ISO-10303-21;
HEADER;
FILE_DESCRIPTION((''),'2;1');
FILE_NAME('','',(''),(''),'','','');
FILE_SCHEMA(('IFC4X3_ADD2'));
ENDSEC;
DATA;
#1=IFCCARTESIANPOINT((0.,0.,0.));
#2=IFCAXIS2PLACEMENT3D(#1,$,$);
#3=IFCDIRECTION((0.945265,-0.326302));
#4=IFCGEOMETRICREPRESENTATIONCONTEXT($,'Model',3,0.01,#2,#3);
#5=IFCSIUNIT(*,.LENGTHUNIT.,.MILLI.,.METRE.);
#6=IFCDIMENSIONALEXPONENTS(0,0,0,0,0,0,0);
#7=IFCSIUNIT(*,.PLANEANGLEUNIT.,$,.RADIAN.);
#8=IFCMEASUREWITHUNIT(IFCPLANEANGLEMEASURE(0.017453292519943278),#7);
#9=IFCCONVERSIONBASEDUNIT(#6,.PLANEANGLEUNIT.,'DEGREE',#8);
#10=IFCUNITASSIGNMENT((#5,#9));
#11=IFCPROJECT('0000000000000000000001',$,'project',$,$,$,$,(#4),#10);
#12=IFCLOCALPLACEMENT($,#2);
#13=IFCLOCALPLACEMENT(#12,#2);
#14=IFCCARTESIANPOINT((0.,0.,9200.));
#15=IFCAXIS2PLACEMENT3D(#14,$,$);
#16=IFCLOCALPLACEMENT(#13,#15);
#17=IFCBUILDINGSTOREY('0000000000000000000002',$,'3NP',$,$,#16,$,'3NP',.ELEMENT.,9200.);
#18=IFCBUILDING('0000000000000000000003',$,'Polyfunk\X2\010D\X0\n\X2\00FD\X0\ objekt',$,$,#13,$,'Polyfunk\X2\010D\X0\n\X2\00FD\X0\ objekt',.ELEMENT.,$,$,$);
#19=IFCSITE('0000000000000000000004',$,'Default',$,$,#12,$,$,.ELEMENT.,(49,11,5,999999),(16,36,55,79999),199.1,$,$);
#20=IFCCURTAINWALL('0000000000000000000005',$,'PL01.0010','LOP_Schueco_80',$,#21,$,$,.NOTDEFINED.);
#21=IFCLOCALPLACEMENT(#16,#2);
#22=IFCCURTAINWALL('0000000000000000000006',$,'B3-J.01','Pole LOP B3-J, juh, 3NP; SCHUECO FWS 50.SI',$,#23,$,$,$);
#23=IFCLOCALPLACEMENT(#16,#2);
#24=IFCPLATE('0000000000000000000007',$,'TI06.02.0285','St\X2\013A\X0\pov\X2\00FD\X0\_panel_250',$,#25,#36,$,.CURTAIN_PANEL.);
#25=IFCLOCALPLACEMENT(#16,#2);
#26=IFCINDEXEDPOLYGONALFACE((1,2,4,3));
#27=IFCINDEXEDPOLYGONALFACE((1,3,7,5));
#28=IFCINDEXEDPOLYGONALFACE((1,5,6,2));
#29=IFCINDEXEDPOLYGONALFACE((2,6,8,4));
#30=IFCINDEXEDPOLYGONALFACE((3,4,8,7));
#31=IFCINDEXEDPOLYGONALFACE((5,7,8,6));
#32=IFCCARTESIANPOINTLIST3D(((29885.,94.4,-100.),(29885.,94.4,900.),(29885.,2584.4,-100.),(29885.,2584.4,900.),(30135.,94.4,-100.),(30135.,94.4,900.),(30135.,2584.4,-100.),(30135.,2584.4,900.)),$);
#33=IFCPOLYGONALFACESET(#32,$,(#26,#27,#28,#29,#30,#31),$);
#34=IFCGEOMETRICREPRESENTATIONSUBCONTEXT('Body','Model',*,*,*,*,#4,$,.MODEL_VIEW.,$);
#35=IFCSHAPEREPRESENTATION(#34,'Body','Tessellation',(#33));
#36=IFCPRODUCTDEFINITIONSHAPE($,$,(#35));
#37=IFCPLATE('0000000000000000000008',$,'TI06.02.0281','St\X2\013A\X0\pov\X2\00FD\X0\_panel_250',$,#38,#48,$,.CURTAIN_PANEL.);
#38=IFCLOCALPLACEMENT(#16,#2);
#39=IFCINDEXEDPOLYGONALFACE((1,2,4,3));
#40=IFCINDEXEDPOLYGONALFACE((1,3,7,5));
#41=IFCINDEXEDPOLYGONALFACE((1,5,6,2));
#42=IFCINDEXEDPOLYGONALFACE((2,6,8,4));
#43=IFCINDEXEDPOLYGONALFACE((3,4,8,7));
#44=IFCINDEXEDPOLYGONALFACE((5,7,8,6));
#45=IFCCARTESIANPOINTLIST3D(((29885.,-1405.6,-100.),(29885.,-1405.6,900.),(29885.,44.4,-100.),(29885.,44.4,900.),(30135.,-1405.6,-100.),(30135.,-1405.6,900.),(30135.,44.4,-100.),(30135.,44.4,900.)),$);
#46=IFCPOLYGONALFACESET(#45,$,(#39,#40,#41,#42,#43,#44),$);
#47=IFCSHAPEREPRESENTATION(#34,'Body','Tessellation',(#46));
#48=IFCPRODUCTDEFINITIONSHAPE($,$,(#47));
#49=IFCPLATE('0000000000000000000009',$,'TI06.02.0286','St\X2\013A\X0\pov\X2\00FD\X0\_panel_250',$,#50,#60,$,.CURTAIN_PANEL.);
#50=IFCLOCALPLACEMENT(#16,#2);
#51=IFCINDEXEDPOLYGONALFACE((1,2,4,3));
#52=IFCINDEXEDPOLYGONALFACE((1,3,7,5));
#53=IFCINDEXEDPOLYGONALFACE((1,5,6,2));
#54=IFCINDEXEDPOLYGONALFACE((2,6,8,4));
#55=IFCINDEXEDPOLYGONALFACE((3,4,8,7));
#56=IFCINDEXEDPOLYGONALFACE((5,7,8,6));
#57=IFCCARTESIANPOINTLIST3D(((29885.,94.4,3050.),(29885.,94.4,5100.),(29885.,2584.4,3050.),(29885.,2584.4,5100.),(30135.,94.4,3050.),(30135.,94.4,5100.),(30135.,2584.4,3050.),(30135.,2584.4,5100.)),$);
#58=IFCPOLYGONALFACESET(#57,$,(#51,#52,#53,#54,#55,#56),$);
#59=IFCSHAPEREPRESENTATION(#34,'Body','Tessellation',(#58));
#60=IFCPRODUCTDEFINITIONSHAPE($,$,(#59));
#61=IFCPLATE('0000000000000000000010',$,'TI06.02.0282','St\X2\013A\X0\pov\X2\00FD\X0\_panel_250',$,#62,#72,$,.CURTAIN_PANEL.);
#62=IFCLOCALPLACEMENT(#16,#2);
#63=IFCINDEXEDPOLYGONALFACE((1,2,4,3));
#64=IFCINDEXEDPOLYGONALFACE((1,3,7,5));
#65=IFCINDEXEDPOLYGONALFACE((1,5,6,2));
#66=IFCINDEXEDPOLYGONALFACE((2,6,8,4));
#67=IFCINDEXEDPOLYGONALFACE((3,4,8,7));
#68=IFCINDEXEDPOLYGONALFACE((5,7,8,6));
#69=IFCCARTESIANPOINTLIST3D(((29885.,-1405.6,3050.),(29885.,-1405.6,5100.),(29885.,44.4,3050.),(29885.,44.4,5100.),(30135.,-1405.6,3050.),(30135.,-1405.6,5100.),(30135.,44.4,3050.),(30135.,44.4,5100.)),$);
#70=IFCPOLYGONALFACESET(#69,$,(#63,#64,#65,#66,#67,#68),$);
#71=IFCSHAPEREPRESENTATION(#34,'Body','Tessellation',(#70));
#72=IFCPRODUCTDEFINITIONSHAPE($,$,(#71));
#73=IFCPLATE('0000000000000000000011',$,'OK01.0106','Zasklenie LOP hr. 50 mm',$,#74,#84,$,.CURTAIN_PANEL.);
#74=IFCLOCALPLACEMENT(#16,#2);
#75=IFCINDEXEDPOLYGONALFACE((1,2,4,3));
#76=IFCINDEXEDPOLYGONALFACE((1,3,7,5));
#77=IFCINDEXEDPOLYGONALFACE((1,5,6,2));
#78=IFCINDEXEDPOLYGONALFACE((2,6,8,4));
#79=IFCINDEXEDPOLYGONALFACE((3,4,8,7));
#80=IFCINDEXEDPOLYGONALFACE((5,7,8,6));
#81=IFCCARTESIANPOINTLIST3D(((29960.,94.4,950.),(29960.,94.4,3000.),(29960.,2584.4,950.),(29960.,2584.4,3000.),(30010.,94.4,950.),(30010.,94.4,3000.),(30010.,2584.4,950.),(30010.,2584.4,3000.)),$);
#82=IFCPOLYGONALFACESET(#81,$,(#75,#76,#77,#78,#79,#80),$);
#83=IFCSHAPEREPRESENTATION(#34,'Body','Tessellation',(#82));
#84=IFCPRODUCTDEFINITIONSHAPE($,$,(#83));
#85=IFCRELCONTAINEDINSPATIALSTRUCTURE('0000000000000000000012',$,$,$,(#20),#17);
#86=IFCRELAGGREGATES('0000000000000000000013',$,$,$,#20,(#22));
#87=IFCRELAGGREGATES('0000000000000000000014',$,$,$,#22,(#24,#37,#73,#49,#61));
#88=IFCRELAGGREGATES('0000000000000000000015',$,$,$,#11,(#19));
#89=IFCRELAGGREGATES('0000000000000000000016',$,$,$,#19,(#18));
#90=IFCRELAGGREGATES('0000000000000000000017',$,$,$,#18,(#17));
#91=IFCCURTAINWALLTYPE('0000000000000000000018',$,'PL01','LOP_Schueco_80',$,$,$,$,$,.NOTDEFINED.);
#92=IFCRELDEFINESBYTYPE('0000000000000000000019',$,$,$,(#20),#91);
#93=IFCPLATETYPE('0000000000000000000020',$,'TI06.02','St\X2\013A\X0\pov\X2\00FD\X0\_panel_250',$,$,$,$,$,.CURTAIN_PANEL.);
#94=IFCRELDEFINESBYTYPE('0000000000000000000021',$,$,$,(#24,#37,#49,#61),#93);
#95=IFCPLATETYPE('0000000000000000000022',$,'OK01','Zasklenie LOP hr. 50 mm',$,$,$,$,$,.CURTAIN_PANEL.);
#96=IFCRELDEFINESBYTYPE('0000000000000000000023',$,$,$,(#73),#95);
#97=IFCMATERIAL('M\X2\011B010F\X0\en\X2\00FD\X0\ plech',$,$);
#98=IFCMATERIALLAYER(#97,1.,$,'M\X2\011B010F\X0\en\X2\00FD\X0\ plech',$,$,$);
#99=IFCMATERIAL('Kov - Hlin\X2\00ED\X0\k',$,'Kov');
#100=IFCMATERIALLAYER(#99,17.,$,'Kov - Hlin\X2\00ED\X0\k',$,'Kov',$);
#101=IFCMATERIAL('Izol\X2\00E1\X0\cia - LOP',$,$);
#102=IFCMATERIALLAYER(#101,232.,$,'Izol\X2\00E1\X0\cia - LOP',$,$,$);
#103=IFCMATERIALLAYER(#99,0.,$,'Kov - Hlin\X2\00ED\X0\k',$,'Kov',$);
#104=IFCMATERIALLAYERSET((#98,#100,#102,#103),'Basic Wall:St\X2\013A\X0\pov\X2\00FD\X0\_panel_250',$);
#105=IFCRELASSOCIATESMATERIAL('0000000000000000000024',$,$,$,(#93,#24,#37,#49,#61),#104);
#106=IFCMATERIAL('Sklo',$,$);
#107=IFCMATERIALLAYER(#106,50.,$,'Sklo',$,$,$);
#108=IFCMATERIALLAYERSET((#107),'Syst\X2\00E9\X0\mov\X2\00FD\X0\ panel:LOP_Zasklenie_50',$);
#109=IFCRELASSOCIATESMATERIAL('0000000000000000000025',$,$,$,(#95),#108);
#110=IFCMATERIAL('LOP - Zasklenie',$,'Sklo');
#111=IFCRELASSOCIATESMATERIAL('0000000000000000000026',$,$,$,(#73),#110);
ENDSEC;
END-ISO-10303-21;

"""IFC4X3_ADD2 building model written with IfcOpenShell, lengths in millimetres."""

from ifc_helpers import new_model, entity, si_unit, converted_unit, direction, frame, frame_2d, origin, origin_2d_with_axis, place, context, subcontext, project, spatial, rectangle, extrude, source, transform, mapped, material, layer, layer_set, layer_usage, type_object, type_shapes, element, aggregate, save


model = new_model("IFC4X3_ADD2")

# Units and contexts
model_context = context("Model", 3, precision=0.01, world=origin(), true_north=direction((0.945265, -0.326302)))
body_context = subcontext(model_context, "Body", "Model", "MODEL_VIEW")
ifc_project = project(units=[si_unit("LENGTHUNIT", "METRE", prefix="MILLI"), converted_unit("PLANEANGLEUNIT", "DEGREE", entity("IfcPlaneAngleMeasure", 0.017453292519943278), si_unit("PLANEANGLEUNIT", "RADIAN"), dimensions=[0, 0, 0, 0, 0, 0, 0])], contexts=[model_context])

# Site, building, storey
site_placement = place(None, origin())
site = spatial("IfcSite", under=ifc_project, at=site_placement, Name="Default", CompositionType="ELEMENT", RefLatitude=(49, 11, 5, 999999), RefLongitude=(16, 36, 55, 79999), RefElevation=199.1)
building_placement = place(site_placement, origin())
building = spatial("IfcBuilding", under=site, at=building_placement, Name="Polyfunkčný objekt", LongName="Polyfunkčný objekt", CompositionType="ELEMENT")
storey_placement = place(building_placement, frame((0.0, 0.0, 9200.0)))
storey = spatial("IfcBuildingStorey", under=building, at=storey_placement, Name="3NP", LongName="3NP", CompositionType="ELEMENT", Elevation=9200.0)

# Shared definitions
curtain_wall_type = type_object("IfcCurtainWallType", Name="PL01", Description="LOP_Schueco_80", PredefinedType="NOTDEFINED")

# Curtain walls
curtain_wall_1_placement = place(storey_placement, frame((0.0, 0.0, -9200.0)))
curtain_wall_1 = element("IfcCurtainWall", 1, at=curtain_wall_1_placement, inside=storey, type_object=curtain_wall_type, Name="PL01.0010", Description="LOP_Schueco_80", PredefinedType="NOTDEFINED")
curtain_wall_2 = element("IfcCurtainWall", 2, Name="B3-J.01", Description="Pole LOP B3-J, juh, 3NP; SCHUECO FWS 50.SI")
aggregate(curtain_wall_1, [curtain_wall_2])

# Plates
ifc_material_1 = material(Name="Měďený plech")
ifc_layer_1 = layer(ifc_material_1, 1.0, Name="Měďený plech")
ifc_material_2 = material(Name="Kov - Hliník", Category="Kov")
ifc_layer_2 = layer(ifc_material_2, 17.0, Name="Kov - Hliník", Category="Kov")
ifc_material_3 = material(Name="Izolácia - LOP")
ifc_layer_3 = layer(ifc_material_3, 232.0, Name="Izolácia - LOP")
ifc_layer_4 = layer(ifc_material_2, 0.0, Name="Kov - Hliník", Category="Kov")
ifc_layer_set_1 = layer_set([ifc_layer_1, ifc_layer_2, ifc_layer_3, ifc_layer_4], Name="Basic Wall:Stĺpový_panel_250")
ifc_layer_usage_1 = layer_usage(ifc_layer_set_1, "AXIS2", "POSITIVE", -125.0)
plate_type_1 = type_object("IfcPlateType", Name="TI06.02", Description="Stĺpový_panel_250", PredefinedType="CURTAIN_PANEL", material=ifc_layer_set_1)
plate_1_placement = place(storey_placement, frame((30010.0, 2584.4, -100.0), z_axis=(0.0, 0.0, 1.0), x_axis=(0.0, -1.0, 0.0)))
plate_1 = element("IfcPlate", 3, at=plate_1_placement, type_object=plate_type_1, material=ifc_layer_usage_1, Name="TI06.02.0285", Description="Stĺpový_panel_250", PredefinedType="CURTAIN_PANEL", context=body_context, shape_type="SweptSolid", body=[
    extrude(rectangle(XDim=250.0, YDim=2490.0, at=frame_2d((0.0, 0.0), x_axis=(1.0, 0.0))), frame((1245.0, 0.0, 0.0), z_axis=(0.0, 0.0, 1.0), x_axis=(0.0, 1.0, 0.0)), (0.0, 0.0, 1.0), 1000.0),
])
ifc_layer_usage_2 = layer_usage(ifc_layer_set_1, "AXIS2", "POSITIVE", -125.0)
plate_2_placement = place(storey_placement, frame((30010.0, 44.4, -100.0), z_axis=(0.0, 0.0, 1.0), x_axis=(0.0, -1.0, 0.0)))
plate_2 = element("IfcPlate", 4, at=plate_2_placement, type_object=plate_type_1, material=ifc_layer_usage_2, Name="TI06.02.0281", Description="Stĺpový_panel_250", PredefinedType="CURTAIN_PANEL", context=body_context, shape_type="SweptSolid", body=[
    extrude(rectangle(XDim=250.0, YDim=1450.0, at=frame_2d((0.0, 0.0), x_axis=(1.0, 0.0))), frame((725.0, 0.0, 0.0), z_axis=(0.0, 0.0, 1.0), x_axis=(0.0, 1.0, 0.0)), (0.0, 0.0, 1.0), 1000.0),
])
ifc_layer_usage_3 = layer_usage(ifc_layer_set_1, "AXIS2", "POSITIVE", -125.0)
plate_3_placement = place(storey_placement, frame((30010.0, 2584.4, 3050.0), z_axis=(0.0, 0.0, 1.0), x_axis=(0.0, -1.0, 0.0)))
plate_3 = element("IfcPlate", 5, at=plate_3_placement, type_object=plate_type_1, material=ifc_layer_usage_3, Name="TI06.02.0286", Description="Stĺpový_panel_250", PredefinedType="CURTAIN_PANEL", context=body_context, shape_type="SweptSolid", body=[
    extrude(rectangle(XDim=250.0, YDim=2490.0, at=frame_2d((0.0, 0.0), x_axis=(1.0, 0.0))), frame((1245.0, 0.0, 0.0), z_axis=(0.0, 0.0, 1.0), x_axis=(0.0, 1.0, 0.0)), (0.0, 0.0, 1.0), 2050.0),
])
ifc_layer_usage_4 = layer_usage(ifc_layer_set_1, "AXIS2", "POSITIVE", -125.0)
plate_4_placement = place(storey_placement, frame((30010.0, 44.4, 3050.0), z_axis=(0.0, 0.0, 1.0), x_axis=(0.0, -1.0, 0.0)))
plate_4 = element("IfcPlate", 6, at=plate_4_placement, type_object=plate_type_1, material=ifc_layer_usage_4, Name="TI06.02.0282", Description="Stĺpový_panel_250", PredefinedType="CURTAIN_PANEL", context=body_context, shape_type="SweptSolid", body=[
    extrude(rectangle(XDim=250.0, YDim=1450.0, at=frame_2d((0.0, 0.0), x_axis=(1.0, 0.0))), frame((725.0, 0.0, 0.0), z_axis=(0.0, 0.0, 1.0), x_axis=(0.0, 1.0, 0.0)), (0.0, 0.0, 1.0), 2050.0),
])
ifc_material_4 = material(Name="LOP - Zasklenie", Category="Sklo")
ifc_material_5 = material(Name="Sklo")
ifc_layer_5 = layer(ifc_material_5, 50.0, Name="Sklo")
ifc_layer_set_2 = layer_set([ifc_layer_5], Name="Systémový panel:LOP_Zasklenie_50")
plate_type_2 = type_object("IfcPlateType", Name="OK01", Description="Zasklenie LOP hr. 50 mm", PredefinedType="CURTAIN_PANEL", material=ifc_layer_set_2)
shared_shape_1 = source(origin(), body_context, "Body", "SweptSolid", [
    extrude(rectangle(XDim=50.0, YDim=2490.0, at=origin_2d_with_axis()), frame((0.0, -25.0, 0.0), z_axis=(0.0, 0.0, 1.0), x_axis=(0.0, 1.0, 0.0)), (0.0, 0.0, 1.0), 2050.0),
])
type_shapes(plate_type_2, [shared_shape_1])
plate_5_placement = place(curtain_wall_1_placement, frame((30010.0, 1339.4, 10150.0), z_axis=(0.0, 0.0, 1.0), x_axis=(0.0, -1.0, 0.0)))
plate_5 = element("IfcPlate", 7, at=plate_5_placement, type_object=plate_type_2, material=ifc_material_4, Name="OK01.0106", Description="Zasklenie LOP hr. 50 mm", PredefinedType="CURTAIN_PANEL", context=body_context, shape_type="MappedRepresentation", body=[
    mapped(shared_shape_1, transform((0.0, 0.0, 0.0), scale=1.0)),
])
aggregate(curtain_wall_2, [plate_1, plate_2, plate_5, plate_3, plate_4])

save(model, "model.ifc")
